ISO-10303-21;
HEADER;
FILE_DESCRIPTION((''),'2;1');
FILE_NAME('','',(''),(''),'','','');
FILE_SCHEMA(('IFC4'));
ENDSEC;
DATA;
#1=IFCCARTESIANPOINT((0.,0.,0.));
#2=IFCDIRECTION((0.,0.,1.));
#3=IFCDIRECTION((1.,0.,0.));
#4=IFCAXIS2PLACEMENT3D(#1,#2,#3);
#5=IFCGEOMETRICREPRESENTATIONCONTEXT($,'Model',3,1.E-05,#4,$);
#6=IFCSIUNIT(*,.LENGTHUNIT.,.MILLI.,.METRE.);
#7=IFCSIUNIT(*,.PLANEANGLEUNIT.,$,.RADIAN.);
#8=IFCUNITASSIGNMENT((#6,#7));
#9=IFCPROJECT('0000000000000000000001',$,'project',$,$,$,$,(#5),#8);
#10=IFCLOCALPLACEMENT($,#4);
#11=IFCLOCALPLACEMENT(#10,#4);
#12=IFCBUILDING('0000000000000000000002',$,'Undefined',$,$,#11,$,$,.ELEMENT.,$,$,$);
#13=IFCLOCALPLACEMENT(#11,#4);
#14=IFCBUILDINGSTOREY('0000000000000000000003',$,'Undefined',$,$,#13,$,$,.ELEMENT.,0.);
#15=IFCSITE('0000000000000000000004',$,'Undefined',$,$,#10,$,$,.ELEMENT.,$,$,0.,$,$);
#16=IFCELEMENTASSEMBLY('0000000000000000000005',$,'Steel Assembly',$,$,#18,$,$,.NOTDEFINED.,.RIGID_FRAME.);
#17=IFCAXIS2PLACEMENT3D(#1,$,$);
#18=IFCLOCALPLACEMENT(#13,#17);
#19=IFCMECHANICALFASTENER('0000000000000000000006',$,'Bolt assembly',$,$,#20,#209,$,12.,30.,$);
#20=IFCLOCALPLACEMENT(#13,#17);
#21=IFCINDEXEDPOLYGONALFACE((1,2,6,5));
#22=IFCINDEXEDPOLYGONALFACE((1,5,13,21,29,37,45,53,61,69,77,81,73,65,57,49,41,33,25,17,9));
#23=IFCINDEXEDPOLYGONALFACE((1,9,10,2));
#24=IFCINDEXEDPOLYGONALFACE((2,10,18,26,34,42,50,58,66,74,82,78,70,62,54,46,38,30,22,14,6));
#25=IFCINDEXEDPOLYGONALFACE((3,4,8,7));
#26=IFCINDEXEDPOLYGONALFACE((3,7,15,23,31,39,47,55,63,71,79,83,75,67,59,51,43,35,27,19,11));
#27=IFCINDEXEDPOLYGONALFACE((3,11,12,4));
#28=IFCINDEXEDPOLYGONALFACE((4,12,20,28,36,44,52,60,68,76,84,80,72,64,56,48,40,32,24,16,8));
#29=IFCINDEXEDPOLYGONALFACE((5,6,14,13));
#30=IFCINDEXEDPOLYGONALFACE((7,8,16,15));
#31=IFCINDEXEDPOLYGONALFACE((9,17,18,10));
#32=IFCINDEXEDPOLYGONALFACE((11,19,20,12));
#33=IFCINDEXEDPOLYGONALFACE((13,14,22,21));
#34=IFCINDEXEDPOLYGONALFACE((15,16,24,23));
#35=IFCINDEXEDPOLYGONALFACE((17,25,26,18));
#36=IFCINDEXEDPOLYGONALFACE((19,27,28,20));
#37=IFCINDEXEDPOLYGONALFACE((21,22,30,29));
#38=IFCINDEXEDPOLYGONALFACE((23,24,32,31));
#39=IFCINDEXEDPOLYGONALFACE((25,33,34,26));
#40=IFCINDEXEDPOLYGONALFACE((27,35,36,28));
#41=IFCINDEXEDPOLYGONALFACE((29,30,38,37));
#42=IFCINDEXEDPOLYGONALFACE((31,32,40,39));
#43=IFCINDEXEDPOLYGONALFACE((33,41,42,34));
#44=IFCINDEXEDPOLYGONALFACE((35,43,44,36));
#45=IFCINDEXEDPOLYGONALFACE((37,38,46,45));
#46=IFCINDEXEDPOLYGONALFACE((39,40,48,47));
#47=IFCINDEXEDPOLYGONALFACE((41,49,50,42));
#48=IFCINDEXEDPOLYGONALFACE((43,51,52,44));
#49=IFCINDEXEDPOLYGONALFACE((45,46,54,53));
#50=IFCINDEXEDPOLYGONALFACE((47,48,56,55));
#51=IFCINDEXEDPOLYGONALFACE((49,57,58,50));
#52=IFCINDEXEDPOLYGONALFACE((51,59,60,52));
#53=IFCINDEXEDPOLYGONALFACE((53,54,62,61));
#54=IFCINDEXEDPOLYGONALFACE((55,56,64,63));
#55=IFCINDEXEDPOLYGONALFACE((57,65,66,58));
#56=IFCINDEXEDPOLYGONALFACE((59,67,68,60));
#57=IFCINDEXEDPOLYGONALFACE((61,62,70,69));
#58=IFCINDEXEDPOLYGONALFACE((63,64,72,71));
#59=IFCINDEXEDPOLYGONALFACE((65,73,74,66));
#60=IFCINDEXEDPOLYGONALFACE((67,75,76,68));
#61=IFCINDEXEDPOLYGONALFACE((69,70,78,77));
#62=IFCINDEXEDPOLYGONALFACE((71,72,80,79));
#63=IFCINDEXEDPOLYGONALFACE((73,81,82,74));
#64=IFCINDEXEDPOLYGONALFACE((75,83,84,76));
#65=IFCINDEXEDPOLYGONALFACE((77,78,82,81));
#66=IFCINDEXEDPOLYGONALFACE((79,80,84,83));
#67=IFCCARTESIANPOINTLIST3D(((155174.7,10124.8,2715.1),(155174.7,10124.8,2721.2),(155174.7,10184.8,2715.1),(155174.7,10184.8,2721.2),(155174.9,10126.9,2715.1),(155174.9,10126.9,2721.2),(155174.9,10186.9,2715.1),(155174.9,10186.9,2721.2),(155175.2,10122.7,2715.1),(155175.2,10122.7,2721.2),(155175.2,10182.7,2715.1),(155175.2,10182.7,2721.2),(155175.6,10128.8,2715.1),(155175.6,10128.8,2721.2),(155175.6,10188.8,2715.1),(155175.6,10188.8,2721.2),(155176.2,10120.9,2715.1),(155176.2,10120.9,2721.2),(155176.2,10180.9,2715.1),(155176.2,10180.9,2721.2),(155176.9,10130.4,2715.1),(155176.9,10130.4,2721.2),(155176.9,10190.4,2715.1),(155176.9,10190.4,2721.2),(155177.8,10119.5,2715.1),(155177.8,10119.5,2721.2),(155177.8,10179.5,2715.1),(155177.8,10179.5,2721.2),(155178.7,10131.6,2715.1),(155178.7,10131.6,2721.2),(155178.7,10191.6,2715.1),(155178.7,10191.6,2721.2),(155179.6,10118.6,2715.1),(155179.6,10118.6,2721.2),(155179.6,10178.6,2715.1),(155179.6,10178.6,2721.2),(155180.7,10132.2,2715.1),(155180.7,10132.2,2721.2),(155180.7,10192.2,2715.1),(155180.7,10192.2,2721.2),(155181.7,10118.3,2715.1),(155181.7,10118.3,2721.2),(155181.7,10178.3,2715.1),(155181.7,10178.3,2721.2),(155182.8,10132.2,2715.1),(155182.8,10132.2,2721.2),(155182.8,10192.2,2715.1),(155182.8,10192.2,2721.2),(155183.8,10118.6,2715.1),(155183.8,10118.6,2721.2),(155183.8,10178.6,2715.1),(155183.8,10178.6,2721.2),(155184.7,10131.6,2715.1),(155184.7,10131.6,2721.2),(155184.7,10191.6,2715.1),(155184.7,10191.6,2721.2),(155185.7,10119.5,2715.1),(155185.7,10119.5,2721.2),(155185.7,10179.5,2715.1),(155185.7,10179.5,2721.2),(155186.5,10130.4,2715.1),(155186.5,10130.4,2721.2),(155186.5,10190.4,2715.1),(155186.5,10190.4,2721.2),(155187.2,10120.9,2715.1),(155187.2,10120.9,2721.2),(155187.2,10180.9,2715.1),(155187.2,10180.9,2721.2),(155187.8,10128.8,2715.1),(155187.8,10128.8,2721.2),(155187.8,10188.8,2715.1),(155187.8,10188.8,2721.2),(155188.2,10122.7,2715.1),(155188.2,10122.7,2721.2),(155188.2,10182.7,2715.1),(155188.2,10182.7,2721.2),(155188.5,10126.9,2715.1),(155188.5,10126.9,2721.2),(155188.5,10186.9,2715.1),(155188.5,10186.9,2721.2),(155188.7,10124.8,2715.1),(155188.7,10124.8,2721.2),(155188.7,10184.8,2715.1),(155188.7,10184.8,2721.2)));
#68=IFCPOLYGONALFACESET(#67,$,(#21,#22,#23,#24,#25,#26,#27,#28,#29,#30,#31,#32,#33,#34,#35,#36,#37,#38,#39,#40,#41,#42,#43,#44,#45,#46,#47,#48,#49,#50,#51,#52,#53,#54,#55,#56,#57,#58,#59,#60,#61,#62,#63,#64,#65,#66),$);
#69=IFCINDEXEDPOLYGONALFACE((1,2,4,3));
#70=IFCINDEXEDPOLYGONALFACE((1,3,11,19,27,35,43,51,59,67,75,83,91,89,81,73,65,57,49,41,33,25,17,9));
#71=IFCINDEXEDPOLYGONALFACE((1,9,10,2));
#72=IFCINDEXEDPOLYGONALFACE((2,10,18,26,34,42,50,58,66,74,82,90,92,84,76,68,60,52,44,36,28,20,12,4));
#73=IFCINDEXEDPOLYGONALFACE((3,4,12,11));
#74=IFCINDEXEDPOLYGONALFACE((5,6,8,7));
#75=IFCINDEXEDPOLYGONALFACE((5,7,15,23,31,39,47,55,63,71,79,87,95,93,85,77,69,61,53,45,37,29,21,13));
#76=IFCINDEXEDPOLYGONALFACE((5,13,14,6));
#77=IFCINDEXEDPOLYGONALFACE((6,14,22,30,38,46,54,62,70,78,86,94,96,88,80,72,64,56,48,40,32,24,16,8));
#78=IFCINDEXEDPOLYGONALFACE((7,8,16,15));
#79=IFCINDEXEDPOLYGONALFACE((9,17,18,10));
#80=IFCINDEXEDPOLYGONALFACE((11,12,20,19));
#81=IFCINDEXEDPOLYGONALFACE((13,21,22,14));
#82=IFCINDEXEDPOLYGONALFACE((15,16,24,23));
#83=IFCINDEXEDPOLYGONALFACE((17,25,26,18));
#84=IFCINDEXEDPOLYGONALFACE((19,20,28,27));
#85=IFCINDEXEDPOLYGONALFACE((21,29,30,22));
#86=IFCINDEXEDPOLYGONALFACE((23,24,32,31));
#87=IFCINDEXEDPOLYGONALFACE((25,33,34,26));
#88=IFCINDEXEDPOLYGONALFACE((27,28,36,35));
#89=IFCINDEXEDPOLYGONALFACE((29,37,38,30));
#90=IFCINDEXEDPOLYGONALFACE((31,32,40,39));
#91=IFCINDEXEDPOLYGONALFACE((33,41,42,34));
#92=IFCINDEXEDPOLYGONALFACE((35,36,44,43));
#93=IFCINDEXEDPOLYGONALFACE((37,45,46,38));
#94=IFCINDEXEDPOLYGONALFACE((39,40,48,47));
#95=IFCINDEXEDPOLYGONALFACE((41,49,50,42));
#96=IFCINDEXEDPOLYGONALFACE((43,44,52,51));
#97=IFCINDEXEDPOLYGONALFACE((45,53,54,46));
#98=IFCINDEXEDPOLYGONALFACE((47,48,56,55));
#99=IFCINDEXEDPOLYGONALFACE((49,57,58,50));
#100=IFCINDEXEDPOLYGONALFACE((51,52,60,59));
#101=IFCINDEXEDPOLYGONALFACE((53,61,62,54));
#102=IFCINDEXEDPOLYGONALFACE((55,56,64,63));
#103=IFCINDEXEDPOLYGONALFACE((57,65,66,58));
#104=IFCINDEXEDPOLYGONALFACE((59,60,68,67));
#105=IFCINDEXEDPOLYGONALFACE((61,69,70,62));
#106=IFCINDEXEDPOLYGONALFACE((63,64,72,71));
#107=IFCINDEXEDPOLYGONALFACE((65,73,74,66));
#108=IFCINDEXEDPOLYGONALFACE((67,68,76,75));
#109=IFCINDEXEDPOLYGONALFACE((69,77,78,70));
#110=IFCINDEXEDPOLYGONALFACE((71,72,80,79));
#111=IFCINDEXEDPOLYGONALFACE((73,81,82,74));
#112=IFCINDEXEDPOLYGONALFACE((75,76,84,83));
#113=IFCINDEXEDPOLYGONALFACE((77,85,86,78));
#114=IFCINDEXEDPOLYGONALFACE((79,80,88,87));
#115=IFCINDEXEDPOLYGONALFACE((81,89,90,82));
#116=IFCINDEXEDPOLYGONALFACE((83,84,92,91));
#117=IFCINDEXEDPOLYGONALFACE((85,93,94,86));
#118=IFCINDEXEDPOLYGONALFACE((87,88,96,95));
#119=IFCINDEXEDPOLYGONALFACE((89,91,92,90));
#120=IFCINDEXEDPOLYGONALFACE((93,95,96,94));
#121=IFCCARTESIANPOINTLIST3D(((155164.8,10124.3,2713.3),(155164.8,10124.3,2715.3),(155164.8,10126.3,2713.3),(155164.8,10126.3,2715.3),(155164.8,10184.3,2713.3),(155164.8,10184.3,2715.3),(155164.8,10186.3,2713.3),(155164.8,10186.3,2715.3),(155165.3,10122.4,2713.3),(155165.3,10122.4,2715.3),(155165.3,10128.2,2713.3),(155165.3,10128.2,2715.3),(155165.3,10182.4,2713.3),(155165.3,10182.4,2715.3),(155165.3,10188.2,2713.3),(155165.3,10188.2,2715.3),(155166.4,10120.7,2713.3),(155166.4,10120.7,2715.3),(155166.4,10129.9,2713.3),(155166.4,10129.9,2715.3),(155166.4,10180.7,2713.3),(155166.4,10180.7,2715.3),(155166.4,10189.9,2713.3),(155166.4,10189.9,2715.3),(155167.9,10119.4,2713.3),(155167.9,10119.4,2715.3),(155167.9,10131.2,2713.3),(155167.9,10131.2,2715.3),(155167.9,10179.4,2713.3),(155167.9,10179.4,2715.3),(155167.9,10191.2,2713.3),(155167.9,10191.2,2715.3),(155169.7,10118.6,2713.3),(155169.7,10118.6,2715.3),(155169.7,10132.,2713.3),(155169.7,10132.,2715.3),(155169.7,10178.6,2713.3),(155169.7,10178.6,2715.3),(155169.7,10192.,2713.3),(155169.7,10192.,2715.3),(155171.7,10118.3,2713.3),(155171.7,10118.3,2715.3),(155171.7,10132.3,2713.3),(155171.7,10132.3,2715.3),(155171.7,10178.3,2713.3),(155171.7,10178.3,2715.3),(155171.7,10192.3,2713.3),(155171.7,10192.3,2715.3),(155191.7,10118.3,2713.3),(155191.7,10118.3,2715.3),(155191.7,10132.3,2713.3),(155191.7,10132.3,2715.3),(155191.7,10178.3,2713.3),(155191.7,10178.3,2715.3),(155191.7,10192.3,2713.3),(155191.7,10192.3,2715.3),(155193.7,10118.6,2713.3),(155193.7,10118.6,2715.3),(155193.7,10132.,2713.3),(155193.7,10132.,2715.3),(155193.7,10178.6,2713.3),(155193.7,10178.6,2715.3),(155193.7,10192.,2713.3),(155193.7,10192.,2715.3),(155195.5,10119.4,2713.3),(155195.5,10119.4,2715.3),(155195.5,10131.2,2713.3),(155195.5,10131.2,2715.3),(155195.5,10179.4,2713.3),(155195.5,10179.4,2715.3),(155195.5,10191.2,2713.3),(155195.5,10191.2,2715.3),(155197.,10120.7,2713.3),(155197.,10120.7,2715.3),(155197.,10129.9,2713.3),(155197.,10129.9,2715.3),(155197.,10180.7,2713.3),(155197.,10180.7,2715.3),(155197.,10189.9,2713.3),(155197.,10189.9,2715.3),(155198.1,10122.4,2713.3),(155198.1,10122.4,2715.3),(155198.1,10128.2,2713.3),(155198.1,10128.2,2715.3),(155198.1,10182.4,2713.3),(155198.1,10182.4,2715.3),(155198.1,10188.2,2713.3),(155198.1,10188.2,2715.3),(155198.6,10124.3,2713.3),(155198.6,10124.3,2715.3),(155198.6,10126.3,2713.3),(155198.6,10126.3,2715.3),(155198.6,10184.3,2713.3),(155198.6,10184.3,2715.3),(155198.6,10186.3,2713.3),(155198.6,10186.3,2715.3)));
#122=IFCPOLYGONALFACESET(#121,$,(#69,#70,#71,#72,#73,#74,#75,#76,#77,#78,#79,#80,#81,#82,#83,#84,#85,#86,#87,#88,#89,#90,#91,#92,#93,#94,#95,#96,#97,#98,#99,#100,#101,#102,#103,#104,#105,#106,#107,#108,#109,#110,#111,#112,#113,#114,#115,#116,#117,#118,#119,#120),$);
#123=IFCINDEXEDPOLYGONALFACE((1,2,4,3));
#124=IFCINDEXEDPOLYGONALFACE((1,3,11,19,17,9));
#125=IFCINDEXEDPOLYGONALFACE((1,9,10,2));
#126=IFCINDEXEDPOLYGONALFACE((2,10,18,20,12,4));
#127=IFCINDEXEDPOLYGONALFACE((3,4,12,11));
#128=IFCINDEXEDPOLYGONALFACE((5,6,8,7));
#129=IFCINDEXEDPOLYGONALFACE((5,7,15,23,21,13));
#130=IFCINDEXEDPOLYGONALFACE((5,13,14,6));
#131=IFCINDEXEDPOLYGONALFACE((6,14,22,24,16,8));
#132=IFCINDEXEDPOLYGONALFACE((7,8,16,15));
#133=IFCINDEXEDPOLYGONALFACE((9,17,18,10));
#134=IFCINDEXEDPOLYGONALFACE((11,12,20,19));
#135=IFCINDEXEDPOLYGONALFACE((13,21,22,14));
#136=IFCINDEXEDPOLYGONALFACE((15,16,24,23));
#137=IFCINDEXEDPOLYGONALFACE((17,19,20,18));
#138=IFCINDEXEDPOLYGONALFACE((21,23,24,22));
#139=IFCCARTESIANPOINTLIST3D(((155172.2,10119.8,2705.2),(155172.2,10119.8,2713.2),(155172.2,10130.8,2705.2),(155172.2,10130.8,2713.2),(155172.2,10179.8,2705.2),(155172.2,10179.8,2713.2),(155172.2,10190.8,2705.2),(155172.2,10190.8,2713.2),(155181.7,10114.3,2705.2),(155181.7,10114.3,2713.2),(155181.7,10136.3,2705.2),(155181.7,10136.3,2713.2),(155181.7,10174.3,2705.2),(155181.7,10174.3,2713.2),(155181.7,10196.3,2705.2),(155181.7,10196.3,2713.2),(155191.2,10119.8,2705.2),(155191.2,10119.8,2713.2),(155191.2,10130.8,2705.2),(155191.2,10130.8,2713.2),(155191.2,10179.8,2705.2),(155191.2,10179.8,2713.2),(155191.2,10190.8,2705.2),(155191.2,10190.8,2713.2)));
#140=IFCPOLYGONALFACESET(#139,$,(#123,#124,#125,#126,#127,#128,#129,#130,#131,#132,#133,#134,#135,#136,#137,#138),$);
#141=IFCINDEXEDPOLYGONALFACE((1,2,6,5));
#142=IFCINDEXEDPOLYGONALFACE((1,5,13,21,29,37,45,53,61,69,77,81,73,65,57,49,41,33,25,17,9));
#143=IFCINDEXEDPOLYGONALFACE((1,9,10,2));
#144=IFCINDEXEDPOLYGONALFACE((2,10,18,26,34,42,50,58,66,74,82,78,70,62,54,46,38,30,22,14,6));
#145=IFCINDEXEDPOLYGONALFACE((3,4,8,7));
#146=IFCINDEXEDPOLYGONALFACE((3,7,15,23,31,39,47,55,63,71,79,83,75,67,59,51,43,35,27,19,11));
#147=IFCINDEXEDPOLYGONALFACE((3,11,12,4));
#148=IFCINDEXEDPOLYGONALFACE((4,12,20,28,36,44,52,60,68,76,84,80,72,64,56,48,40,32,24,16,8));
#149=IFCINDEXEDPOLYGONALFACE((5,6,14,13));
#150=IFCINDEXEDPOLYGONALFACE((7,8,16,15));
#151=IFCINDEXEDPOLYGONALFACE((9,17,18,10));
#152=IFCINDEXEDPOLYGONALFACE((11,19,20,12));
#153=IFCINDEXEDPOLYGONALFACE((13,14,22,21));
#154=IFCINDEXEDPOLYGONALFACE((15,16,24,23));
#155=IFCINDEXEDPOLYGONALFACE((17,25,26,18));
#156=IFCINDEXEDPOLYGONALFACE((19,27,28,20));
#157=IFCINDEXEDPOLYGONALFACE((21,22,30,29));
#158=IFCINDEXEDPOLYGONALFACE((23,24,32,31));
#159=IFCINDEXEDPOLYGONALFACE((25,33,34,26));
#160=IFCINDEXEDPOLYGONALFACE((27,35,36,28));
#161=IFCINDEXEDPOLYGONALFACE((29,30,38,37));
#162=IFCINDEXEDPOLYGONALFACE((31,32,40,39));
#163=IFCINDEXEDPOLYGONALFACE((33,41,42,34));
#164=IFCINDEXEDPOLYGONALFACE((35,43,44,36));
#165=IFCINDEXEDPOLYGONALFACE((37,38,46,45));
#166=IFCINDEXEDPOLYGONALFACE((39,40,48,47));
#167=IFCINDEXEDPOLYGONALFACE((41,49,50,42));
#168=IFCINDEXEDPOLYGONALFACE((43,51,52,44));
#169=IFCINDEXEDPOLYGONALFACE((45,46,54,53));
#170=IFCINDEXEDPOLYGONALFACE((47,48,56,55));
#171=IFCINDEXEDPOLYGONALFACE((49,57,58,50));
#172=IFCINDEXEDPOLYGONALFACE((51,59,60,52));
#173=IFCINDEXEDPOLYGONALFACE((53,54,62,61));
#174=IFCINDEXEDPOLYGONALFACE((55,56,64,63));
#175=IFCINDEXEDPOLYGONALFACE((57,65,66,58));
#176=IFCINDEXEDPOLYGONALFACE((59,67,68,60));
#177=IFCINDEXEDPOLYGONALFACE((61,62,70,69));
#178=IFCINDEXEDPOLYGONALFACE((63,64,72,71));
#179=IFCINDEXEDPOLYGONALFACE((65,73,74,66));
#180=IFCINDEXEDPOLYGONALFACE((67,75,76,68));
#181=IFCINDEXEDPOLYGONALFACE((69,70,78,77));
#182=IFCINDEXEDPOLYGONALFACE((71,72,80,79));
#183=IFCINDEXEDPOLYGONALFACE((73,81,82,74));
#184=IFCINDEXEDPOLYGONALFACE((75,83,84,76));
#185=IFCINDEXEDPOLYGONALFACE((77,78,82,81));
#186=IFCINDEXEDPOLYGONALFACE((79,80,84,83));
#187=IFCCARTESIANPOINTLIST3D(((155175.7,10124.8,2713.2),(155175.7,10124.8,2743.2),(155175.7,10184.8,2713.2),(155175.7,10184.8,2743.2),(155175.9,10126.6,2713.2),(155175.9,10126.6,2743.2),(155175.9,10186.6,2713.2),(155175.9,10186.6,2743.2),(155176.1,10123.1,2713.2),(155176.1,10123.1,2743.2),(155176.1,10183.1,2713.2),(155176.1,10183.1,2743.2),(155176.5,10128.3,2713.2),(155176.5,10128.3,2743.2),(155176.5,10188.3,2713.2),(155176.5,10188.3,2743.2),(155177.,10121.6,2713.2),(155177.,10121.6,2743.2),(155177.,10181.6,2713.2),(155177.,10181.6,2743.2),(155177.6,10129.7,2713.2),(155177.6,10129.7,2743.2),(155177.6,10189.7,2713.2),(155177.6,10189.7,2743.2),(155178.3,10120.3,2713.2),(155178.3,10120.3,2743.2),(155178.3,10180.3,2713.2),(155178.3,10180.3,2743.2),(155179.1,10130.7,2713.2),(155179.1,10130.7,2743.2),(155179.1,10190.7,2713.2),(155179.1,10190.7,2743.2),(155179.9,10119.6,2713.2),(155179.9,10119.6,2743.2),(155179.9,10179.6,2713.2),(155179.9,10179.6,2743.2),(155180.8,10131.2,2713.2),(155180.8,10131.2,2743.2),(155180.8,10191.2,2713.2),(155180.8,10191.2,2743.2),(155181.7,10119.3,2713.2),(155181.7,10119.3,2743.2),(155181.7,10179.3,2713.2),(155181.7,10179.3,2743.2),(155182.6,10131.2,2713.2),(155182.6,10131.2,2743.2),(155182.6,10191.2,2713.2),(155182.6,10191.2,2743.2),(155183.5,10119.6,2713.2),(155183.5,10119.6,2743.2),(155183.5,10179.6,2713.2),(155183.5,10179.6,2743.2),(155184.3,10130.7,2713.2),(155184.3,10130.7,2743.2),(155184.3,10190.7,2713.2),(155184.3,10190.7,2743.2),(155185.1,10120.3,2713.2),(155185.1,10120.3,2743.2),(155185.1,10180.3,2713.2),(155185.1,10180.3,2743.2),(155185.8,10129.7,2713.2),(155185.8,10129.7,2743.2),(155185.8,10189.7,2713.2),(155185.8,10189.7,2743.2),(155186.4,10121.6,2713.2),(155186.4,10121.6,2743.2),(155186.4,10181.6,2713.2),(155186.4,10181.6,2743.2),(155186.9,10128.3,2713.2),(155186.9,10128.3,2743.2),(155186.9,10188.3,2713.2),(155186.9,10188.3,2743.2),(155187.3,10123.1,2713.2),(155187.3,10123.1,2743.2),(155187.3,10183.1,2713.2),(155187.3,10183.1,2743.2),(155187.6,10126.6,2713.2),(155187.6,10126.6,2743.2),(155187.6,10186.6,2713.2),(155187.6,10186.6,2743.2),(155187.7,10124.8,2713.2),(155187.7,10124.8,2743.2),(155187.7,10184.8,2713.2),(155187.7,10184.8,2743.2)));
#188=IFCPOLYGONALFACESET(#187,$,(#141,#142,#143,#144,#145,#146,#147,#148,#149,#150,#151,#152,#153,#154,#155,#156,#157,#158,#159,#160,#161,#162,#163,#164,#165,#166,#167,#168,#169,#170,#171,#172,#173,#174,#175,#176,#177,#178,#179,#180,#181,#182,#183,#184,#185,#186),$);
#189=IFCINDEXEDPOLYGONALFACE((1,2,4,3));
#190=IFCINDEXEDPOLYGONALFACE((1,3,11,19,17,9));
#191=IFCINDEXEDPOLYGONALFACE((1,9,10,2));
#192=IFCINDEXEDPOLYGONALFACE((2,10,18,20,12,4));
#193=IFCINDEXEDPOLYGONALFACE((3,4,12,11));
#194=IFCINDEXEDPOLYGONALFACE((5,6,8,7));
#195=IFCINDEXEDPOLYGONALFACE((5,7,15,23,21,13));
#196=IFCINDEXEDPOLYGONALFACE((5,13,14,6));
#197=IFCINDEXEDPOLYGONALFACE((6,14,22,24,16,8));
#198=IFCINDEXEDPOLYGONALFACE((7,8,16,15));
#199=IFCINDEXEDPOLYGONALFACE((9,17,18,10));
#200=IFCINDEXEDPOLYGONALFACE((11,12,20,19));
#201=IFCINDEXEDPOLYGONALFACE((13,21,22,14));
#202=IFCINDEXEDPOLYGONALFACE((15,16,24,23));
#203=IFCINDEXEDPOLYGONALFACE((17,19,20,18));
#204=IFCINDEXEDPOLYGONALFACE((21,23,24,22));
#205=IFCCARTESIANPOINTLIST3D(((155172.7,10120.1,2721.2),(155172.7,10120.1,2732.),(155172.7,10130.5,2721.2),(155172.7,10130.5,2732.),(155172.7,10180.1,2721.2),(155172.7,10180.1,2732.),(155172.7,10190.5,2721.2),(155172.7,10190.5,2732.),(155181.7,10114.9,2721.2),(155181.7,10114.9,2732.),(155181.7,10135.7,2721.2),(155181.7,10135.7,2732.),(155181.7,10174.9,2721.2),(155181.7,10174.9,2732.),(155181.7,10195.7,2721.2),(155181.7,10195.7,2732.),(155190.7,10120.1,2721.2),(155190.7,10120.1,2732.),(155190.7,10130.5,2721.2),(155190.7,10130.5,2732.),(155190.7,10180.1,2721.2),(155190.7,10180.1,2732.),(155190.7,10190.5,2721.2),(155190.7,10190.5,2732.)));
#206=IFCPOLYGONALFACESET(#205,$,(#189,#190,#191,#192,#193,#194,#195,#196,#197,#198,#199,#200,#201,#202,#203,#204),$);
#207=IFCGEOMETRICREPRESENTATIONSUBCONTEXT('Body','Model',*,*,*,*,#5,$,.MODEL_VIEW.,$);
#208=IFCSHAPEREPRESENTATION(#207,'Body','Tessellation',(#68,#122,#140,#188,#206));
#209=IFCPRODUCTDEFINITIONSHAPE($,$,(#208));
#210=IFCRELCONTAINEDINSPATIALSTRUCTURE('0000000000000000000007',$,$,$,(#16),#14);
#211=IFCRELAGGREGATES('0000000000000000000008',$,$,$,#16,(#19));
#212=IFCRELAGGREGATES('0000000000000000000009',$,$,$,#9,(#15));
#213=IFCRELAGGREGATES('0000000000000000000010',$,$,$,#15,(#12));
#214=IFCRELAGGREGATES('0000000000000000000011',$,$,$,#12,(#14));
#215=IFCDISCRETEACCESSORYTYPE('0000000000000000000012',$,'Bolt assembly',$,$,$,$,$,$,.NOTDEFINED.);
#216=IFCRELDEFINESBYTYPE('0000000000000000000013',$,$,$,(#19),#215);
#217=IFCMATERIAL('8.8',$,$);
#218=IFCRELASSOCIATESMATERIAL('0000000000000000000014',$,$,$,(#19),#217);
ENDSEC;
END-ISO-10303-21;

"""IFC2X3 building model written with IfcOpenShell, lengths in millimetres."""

from ifc_helpers import new_model, si_unit, frame, frame_2d, origin_with_axes, origin_2d_with_axis, place, context, subcontext, project, spatial, polyline, circle_curve, parameter, trimmed, segment, composite_curve, circle, outline, extrude, source, transform, mapped, material, type_object, element, aggregate, save


model = new_model("IFC2X3")

# Units and contexts
model_context = context("Model", 3, precision=1e-05, world=origin_with_axes())
body_context = subcontext(model_context, "Body", "Model", "MODEL_VIEW")
ifc_project = project(units=[si_unit("LENGTHUNIT", "METRE", prefix="MILLI"), si_unit("PLANEANGLEUNIT", "RADIAN")], contexts=[model_context])

# Site, building, storey
site_placement = place(None, origin_with_axes())
site = spatial("IfcSite", under=ifc_project, at=site_placement, Name="Undefined", CompositionType="ELEMENT", RefElevation=0.0)
building_placement = place(site_placement, origin_with_axes())
building = spatial("IfcBuilding", under=site, at=building_placement, Name="Undefined", CompositionType="ELEMENT")
storey_placement = place(building_placement, origin_with_axes())
storey = spatial("IfcBuildingStorey", under=building, at=storey_placement, Name="Undefined", CompositionType="ELEMENT", Elevation=0.0)

# Shared definitions
discrete_accessory_type_1 = type_object("IfcDiscreteAccessoryType", Name="Bolt assembly")

# Shared definitions
ifc_material_1 = material(Name="8.8")

# Element assembly, mechanical fastener
assembly_1_placement = place(storey_placement, origin_with_axes())
assembly_1 = element("IfcElementAssembly", 1, at=assembly_1_placement, inside=storey, Name="Steel Assembly", AssemblyPlace="NOTDEFINED", PredefinedType="RIGID_FRAME")
shared_shape_1 = source(origin_with_axes(), body_context, "Body", "SweptSolid", [
    extrude(circle(Radius=7.0, at=origin_2d_with_axis()), frame((0.0, -3.1, 0.0), z_axis=(0.0, 1.0, 0.0), x_axis=(1.0, 0.0, 0.0)), (0.0, 0.0, 1.0), 6.1),
    extrude(outline(composite_curve([segment(polyline([(7.0, 10.0), (7.0, -10.0)]), True, "CONTINUOUS"), segment(trimmed(circle_curve(frame_2d((0.0, -10.0), x_axis=(1.0, 0.0)), 7.0), [parameter(0.0)], [parameter(3.1416)], False, "PARAMETER"), True, "CONTINUOUS"), segment(polyline([(-7.0, -10.0), (-7.0, 10.0)]), True, "CONTINUOUS"), segment(trimmed(circle_curve(frame_2d((0.0, 10.0), x_axis=(-1.0, 0.0)), 7.0), [parameter(0.0)], [parameter(3.1416)], False, "PARAMETER"), True, "DISCONTINUOUS")], self_intersect=False)), frame((0.0, -4.9, 0.0), z_axis=(0.0, 1.0, 0.0), x_axis=(1.0, 0.0, 0.0)), (0.0, 0.0, 1.0), 2.0),
    extrude(outline(polyline([(11.0, 0.0), (5.5, 9.5), (-5.5, 9.5), (-11.0, 0.0), (-5.5, -9.5), (5.5, -9.5), (11.0, 0.0)])), frame((0.0, -13.0, 0.0), z_axis=(0.0, 1.0, 0.0), x_axis=(1.0, 0.0, 0.0)), (0.0, 0.0, 1.0), 8.0),
    extrude(circle(Radius=6.0, at=origin_2d_with_axis()), frame((0.0, -5.0, 0.0), z_axis=(0.0, 1.0, 0.0), x_axis=(1.0, 0.0, 0.0)), (0.0, 0.0, 1.0), 30.0),
    extrude(outline(polyline([(10.4, 0.0), (5.2, 9.0), (-5.2, 9.0), (-10.4, 0.0), (-5.2, -9.0), (5.2, -9.0), (10.4, 0.0)])), frame((0.0, 3.0, 0.0), z_axis=(0.0, 1.0, 0.0), x_axis=(1.0, 0.0, 0.0)), (0.0, 0.0, 1.0), 10.8),
])
mechanical_fastener_1_placement = place(assembly_1_placement, frame((155226.7, 10230.3, 2718.2), z_axis=(-1.0, 0.0, 0.0), x_axis=(0.0, -1.0, 0.0)))
mechanical_fastener_1 = element("IfcMechanicalFastener", 2, at=mechanical_fastener_1_placement, type_object=discrete_accessory_type_1, material=ifc_material_1, Name="Bolt assembly", NominalDiameter=12.0, NominalLength=30.0, context=body_context, shape_type="MappedRepresentation", body=[
    mapped(shared_shape_1, transform((45.0, 0.0, 45.0))),
    mapped(shared_shape_1, transform((105.0, 0.0, 45.0))),
])
aggregate(assembly_1, [mechanical_fastener_1])

save(model, "model.ifc")
